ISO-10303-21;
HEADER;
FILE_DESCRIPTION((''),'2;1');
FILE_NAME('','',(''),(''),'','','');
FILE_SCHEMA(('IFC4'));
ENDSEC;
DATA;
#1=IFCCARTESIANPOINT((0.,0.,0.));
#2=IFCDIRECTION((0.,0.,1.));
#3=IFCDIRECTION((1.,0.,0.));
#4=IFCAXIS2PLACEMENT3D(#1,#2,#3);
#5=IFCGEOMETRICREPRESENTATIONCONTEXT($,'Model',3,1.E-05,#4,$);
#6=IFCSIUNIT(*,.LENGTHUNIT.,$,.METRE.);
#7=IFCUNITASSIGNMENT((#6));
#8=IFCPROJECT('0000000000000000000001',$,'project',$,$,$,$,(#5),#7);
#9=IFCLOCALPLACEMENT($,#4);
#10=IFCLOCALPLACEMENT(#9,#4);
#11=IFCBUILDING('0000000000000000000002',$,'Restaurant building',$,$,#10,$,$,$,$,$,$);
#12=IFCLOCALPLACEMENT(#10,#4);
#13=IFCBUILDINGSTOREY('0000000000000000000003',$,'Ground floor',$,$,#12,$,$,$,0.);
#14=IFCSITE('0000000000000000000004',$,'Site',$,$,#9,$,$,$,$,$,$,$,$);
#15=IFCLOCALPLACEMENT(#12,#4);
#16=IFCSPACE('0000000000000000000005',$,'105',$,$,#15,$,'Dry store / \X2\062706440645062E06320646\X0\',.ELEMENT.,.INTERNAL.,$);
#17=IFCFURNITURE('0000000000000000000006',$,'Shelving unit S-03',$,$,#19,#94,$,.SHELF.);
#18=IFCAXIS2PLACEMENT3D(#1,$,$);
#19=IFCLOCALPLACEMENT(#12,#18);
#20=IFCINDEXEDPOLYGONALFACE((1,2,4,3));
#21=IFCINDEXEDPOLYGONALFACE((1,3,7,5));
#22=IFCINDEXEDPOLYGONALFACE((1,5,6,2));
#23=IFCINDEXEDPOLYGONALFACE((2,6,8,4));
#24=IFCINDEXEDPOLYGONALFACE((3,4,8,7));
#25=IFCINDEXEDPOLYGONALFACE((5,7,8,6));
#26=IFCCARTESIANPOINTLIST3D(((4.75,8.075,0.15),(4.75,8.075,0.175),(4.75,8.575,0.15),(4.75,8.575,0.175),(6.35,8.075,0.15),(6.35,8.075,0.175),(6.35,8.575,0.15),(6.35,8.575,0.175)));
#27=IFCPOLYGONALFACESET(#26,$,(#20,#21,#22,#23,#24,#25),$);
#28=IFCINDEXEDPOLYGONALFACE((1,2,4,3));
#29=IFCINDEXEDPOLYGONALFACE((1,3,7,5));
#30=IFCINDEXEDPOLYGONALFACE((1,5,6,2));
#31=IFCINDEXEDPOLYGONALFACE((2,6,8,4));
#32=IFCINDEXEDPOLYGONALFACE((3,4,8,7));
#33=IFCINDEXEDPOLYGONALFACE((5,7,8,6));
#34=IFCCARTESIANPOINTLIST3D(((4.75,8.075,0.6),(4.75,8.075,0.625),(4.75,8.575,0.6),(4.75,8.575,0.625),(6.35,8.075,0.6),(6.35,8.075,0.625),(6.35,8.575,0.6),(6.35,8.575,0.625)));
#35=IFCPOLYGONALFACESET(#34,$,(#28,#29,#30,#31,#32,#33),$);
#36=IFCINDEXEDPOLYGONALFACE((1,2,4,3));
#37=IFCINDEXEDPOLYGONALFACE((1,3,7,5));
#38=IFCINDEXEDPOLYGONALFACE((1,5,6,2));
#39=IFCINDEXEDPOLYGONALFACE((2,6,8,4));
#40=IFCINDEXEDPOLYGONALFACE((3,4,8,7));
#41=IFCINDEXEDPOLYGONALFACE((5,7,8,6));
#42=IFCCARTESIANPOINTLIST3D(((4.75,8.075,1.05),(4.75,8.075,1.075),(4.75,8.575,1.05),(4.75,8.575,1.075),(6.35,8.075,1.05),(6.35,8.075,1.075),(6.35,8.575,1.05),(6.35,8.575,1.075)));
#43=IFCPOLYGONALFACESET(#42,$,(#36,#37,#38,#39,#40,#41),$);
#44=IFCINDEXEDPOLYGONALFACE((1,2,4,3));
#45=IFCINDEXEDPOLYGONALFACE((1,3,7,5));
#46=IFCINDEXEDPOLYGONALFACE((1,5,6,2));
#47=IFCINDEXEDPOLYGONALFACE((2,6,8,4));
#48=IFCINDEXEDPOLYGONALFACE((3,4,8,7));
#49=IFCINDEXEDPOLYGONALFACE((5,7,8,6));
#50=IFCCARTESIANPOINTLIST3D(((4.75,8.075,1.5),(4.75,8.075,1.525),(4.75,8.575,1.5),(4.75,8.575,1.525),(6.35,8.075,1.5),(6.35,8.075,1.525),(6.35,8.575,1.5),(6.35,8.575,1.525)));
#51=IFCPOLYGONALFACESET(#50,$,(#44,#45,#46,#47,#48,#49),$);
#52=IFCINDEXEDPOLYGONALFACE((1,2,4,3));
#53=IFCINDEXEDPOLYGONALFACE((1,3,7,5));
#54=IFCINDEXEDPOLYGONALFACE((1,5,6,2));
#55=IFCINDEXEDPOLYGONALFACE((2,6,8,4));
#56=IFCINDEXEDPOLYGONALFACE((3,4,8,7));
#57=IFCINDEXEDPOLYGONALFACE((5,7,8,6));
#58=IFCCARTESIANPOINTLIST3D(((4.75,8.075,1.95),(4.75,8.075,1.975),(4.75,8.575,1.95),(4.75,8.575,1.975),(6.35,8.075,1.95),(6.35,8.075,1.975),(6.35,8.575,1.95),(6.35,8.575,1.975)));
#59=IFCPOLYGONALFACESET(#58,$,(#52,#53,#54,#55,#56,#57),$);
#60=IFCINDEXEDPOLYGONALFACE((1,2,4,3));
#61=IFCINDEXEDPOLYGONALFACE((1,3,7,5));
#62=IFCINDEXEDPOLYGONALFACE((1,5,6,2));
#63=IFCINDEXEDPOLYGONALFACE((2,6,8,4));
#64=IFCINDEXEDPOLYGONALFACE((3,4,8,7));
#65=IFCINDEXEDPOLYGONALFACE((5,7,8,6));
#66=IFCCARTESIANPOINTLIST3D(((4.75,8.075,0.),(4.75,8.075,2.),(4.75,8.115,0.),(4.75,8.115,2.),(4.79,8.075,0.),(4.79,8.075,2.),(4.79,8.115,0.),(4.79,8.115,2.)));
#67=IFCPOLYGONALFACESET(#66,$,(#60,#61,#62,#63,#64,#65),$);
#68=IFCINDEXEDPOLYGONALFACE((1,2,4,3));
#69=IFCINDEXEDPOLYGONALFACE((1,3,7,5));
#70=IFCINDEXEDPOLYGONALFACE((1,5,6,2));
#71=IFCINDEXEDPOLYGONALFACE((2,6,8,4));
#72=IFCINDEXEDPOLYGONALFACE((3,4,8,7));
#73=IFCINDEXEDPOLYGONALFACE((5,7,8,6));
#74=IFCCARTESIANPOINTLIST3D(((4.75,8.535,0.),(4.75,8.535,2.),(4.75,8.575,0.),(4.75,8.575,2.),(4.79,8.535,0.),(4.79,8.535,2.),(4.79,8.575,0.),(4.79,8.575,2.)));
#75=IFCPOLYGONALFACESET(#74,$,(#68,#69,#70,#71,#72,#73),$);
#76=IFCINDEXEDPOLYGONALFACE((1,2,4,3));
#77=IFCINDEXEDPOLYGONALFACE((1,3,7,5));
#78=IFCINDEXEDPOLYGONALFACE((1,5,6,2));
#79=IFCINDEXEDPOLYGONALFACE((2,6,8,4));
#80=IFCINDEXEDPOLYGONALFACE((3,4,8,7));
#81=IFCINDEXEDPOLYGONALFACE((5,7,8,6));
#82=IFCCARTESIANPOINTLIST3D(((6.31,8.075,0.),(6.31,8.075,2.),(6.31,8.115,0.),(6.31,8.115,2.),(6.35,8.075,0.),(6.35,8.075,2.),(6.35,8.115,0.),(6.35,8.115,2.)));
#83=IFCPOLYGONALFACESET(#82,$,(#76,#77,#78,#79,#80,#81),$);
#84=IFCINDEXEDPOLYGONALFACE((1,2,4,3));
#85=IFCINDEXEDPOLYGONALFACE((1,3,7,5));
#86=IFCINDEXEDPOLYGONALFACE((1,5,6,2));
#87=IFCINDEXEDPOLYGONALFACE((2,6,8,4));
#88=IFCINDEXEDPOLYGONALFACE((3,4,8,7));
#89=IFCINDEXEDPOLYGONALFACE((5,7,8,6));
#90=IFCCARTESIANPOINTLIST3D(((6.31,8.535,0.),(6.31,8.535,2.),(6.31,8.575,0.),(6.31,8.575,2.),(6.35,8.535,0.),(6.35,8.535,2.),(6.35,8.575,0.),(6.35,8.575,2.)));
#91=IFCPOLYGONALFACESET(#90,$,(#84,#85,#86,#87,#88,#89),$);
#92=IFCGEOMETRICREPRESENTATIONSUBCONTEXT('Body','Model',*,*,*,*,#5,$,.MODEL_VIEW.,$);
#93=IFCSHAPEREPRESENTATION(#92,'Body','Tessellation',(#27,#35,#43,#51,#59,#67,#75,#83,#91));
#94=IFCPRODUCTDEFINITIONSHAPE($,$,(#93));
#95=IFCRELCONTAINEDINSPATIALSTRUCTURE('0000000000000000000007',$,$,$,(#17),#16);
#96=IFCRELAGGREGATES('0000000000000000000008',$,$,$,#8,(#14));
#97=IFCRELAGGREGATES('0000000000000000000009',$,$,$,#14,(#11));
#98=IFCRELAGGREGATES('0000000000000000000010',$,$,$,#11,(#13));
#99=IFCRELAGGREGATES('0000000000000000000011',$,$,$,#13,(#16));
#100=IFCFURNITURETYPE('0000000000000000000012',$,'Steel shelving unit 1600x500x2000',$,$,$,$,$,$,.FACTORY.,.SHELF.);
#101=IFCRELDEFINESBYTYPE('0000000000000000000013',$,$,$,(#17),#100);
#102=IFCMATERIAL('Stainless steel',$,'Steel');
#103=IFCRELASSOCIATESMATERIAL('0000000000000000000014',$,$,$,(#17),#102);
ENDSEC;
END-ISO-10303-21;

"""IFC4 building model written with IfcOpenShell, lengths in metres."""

from ifc_helpers import new_model, si_unit, frame, origin, origin_with_axes, origin_2d, place, context, subcontext, project, spatial, rectangle, extrude, source, transform, mapped, material, type_object, type_shapes, element, save


model = new_model("IFC4")

# Units and contexts
model_context = context("Model", 3, precision=1e-05, world=origin_with_axes())
body_context = subcontext(model_context, "Body", "Model", "MODEL_VIEW")
ifc_project = project(units=[si_unit("LENGTHUNIT", "METRE")], contexts=[model_context])

# Site, building, storey
site_placement = place(None, origin_with_axes())
site = spatial("IfcSite", under=ifc_project, at=site_placement, Name="Site")
building_placement = place(site_placement, origin_with_axes())
building = spatial("IfcBuilding", under=site, at=building_placement, Name="Restaurant building")
storey_placement = place(building_placement, origin_with_axes())
storey = spatial("IfcBuildingStorey", under=building, at=storey_placement, Name="Ground floor", Elevation=0.0)

# Shared definitions
space_1_placement = place(storey_placement, origin_with_axes())
space_1 = spatial("IfcSpace", under=storey, at=space_1_placement, Name="105", LongName="Dry store / المخزن", CompositionType="ELEMENT", PredefinedType="INTERNAL")

# Furniture
ifc_material_1 = material(Name="Stainless steel", Category="Steel")
furniture_type_1 = type_object("IfcFurnitureType", Name="Steel shelving unit 1600x500x2000", AssemblyPlace="FACTORY", PredefinedType="SHELF")
shared_shape_1 = source(origin(), body_context, "Body", "SweptSolid", [
    extrude(rectangle(XDim=1.6, YDim=0.5, at=origin_2d()), frame((0.0, 0.0, 0.15)), (0.0, 0.0, 1.0), 0.025),
    extrude(rectangle(XDim=1.6, YDim=0.5, at=origin_2d()), frame((0.0, 0.0, 0.6)), (0.0, 0.0, 1.0), 0.025),
    extrude(rectangle(XDim=1.6, YDim=0.5, at=origin_2d()), frame((0.0, 0.0, 1.05)), (0.0, 0.0, 1.0), 0.025),
    extrude(rectangle(XDim=1.6, YDim=0.5, at=origin_2d()), frame((0.0, 0.0, 1.5)), (0.0, 0.0, 1.0), 0.025),
    extrude(rectangle(XDim=1.6, YDim=0.5, at=origin_2d()), frame((0.0, 0.0, 1.95)), (0.0, 0.0, 1.0), 0.025),
    extrude(rectangle(XDim=0.04, YDim=0.04, at=origin_2d()), frame((-0.78, -0.23, 0.0)), (0.0, 0.0, 1.0), 2.0),
    extrude(rectangle(XDim=0.04, YDim=0.04, at=origin_2d()), frame((-0.78, 0.23, 0.0)), (0.0, 0.0, 1.0), 2.0),
    extrude(rectangle(XDim=0.04, YDim=0.04, at=origin_2d()), frame((0.78, -0.23, 0.0)), (0.0, 0.0, 1.0), 2.0),
    extrude(rectangle(XDim=0.04, YDim=0.04, at=origin_2d()), frame((0.78, 0.23, 0.0)), (0.0, 0.0, 1.0), 2.0),
])
type_shapes(furniture_type_1, [shared_shape_1])
furniture_1_placement = place(storey_placement, frame((5.55, 8.325, 0.0)))
element("IfcFurniture", 1, at=furniture_1_placement, inside=space_1, type_object=furniture_type_1, material=ifc_material_1, Name="Shelving unit S-03", PredefinedType="SHELF", context=body_context, shape_type="MappedRepresentation", body=[
    mapped(shared_shape_1, transform((0.0, 0.0, 0.0))),
])

save(model, "model.ifc")
